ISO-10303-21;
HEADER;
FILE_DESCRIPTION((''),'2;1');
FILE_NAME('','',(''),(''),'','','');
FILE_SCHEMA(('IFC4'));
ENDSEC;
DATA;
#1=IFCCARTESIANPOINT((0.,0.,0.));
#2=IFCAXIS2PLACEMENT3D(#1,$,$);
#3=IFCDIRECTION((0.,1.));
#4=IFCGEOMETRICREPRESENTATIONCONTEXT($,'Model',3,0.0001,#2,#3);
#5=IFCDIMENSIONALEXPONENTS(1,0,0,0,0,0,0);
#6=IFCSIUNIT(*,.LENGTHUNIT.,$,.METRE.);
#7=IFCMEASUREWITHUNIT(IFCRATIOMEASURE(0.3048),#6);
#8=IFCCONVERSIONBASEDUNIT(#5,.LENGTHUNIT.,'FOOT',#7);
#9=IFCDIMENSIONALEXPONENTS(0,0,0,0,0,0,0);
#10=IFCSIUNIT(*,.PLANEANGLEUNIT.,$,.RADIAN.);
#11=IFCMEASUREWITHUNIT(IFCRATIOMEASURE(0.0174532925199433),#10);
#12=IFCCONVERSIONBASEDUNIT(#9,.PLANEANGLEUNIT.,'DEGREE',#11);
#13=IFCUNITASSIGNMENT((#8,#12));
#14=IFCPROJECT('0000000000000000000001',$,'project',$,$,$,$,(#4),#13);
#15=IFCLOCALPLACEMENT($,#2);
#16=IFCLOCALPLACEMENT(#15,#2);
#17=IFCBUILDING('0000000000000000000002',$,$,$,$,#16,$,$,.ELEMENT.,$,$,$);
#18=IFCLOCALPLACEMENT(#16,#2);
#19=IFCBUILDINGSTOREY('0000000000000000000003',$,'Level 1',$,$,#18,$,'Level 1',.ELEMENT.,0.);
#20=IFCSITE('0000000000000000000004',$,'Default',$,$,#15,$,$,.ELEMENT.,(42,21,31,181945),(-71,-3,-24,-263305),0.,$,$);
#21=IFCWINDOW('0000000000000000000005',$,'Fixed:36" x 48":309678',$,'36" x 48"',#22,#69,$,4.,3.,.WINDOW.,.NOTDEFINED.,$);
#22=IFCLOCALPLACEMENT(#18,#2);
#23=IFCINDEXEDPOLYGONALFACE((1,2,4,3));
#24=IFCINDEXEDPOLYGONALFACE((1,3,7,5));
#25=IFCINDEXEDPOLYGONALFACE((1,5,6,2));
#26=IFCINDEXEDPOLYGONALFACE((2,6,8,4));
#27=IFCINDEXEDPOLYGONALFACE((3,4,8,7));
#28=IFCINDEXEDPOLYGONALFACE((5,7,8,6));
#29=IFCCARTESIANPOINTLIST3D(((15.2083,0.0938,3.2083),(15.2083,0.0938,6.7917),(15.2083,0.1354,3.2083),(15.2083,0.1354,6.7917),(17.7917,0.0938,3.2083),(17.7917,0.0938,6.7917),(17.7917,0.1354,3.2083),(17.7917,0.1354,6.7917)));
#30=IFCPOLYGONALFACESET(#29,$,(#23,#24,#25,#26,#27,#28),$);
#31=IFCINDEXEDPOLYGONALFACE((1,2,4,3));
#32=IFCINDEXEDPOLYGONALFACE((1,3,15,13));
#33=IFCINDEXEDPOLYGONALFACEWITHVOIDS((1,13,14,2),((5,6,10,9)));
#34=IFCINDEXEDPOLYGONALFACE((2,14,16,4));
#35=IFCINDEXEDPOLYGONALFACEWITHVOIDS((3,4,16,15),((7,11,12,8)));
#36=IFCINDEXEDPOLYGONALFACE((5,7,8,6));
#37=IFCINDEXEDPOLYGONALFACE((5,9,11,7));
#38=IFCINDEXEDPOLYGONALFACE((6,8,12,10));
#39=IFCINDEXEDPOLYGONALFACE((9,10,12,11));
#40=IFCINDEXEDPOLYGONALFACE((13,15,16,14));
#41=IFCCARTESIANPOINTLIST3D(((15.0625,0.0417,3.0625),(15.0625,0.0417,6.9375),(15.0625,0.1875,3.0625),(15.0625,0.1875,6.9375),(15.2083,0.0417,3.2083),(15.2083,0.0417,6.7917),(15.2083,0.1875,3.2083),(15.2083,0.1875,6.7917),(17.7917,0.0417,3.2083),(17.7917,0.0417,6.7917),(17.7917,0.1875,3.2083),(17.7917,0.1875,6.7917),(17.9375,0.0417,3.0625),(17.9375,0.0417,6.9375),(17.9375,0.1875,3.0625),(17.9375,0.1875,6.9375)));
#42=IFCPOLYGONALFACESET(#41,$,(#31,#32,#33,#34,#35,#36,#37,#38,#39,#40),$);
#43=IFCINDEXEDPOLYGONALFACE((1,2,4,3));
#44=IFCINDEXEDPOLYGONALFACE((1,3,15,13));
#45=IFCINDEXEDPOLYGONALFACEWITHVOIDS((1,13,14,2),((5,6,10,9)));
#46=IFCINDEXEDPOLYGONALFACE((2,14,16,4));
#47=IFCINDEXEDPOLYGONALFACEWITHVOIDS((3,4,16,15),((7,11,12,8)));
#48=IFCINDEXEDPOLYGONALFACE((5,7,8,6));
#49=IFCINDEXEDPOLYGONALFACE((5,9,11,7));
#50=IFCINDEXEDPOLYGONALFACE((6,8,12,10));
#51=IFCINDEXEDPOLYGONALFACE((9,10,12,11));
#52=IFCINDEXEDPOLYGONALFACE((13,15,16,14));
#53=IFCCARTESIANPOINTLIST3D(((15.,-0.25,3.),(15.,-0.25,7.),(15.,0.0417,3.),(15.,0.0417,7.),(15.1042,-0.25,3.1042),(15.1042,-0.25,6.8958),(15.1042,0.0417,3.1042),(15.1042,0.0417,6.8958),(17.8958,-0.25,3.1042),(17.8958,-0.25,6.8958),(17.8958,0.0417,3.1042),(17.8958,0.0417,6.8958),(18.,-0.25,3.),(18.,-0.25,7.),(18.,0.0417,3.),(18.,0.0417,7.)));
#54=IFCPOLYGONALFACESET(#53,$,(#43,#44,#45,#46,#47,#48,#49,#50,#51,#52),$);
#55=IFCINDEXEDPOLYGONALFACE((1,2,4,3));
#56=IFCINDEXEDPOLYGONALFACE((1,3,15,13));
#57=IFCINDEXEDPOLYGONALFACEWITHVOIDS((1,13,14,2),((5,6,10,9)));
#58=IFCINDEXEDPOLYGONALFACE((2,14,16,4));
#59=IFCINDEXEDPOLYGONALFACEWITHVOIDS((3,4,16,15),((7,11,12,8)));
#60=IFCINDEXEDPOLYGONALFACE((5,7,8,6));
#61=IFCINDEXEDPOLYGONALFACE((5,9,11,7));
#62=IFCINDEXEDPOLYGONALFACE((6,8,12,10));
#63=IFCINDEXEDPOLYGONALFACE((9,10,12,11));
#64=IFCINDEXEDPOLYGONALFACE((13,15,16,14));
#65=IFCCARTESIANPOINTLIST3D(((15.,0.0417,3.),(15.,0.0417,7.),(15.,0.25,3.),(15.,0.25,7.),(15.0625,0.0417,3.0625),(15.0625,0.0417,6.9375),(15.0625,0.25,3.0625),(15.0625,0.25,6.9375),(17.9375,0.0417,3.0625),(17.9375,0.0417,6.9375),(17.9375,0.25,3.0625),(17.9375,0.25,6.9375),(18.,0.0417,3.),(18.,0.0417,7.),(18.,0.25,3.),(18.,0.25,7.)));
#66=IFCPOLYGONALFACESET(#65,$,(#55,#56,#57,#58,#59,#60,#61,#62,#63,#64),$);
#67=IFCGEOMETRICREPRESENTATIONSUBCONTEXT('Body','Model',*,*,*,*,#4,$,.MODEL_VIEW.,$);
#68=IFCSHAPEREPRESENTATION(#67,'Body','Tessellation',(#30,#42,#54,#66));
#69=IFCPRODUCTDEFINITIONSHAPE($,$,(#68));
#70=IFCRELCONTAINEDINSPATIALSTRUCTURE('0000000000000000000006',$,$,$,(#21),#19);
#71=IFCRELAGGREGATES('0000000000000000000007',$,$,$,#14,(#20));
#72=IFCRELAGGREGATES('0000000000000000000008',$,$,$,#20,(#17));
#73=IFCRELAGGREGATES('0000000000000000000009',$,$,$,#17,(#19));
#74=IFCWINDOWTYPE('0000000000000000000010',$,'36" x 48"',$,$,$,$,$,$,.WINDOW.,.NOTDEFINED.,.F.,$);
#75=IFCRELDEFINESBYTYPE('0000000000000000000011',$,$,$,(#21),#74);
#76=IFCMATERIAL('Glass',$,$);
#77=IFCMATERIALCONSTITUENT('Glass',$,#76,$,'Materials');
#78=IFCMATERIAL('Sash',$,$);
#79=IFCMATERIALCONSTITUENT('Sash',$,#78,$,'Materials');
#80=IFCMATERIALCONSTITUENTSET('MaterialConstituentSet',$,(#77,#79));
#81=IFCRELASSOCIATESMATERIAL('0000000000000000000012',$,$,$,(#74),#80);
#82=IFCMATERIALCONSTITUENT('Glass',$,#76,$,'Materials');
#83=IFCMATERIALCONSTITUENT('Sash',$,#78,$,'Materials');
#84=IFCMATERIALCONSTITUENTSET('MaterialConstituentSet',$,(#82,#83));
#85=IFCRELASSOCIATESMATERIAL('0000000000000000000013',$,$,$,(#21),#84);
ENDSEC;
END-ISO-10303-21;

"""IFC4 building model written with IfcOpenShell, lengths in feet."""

from ifc_helpers import new_model, entity, si_unit, converted_unit, direction, frame, frame_2d, origin, place, context, subcontext, project, spatial, polyline, rectangle, outline, extrude, source, transform, mapped, material, constituent, constituent_set, type_object, type_shapes, element, save


model = new_model("IFC4")

# Units and contexts
model_context = context("Model", 3, precision=0.0001, world=origin(), true_north=direction((0.0, 1.0)))
body_context = subcontext(model_context, "Body", "Model", "MODEL_VIEW")
ifc_project = project(units=[converted_unit("LENGTHUNIT", "FOOT", entity("IfcRatioMeasure", 0.3048), si_unit("LENGTHUNIT", "METRE"), dimensions=[1, 0, 0, 0, 0, 0, 0]), converted_unit("PLANEANGLEUNIT", "DEGREE", entity("IfcRatioMeasure", 0.0174532925199433), si_unit("PLANEANGLEUNIT", "RADIAN"), dimensions=[0, 0, 0, 0, 0, 0, 0])], contexts=[model_context])

# Site, building, storey
site_placement = place(None, origin())
site = spatial("IfcSite", under=ifc_project, at=site_placement, Name="Default", CompositionType="ELEMENT", RefLatitude=(42, 21, 31, 181945), RefLongitude=(-71, -3, -24, -263305), RefElevation=0.0)
building_placement = place(site_placement, origin())
building = spatial("IfcBuilding", under=site, at=building_placement, CompositionType="ELEMENT")
storey_placement = place(building_placement, origin())
storey = spatial("IfcBuildingStorey", under=building, at=storey_placement, Name="Level 1", LongName="Level 1", CompositionType="ELEMENT", Elevation=0.0)

# Shared definitions
placement_1 = place(storey_placement, frame((46.25, 0.0, 0.0), z_axis=(0.0, 0.0, 1.0), x_axis=(-1.0, 0.0, 0.0)))

# Window
ifc_material_1 = material(Name="Glass")
ifc_constituent_1 = constituent(ifc_material_1, Name="Glass", Category="Materials")
ifc_material_2 = material(Name="Sash")
ifc_constituent_2 = constituent(ifc_material_2, Name="Sash", Category="Materials")
ifc_constituent_set_1 = constituent_set(constituents=[ifc_constituent_1, ifc_constituent_2], Name="MaterialConstituentSet")
ifc_constituent_3 = constituent(ifc_material_1, Name="Glass", Category="Materials")
ifc_constituent_4 = constituent(ifc_material_2, Name="Sash", Category="Materials")
ifc_constituent_set_2 = constituent_set(constituents=[ifc_constituent_3, ifc_constituent_4], Name="MaterialConstituentSet")
window_type = type_object("IfcWindowType", Name="36\" x 48\"", ParameterTakesPrecedence=False, PartitioningType="NOTDEFINED", PredefinedType="WINDOW", material=ifc_constituent_set_2)
shared_shape = source(origin(), body_context, "Body", "SweptSolid", [
    extrude(rectangle(XDim=0.0417, YDim=2.5833, at=frame_2d((0.0, 0.0), x_axis=(1.0, 0.0))), frame((1.5, 0.3646, 0.2083), z_axis=(0.0, 0.0, 1.0), x_axis=(0.0, 1.0, 0.0)), (0.0, 0.0, 1.0), 3.5833),
    extrude(outline(polyline([(-1.4375, -1.9375), (1.4375, -1.9375), (1.4375, 1.9375), (-1.4375, 1.9375), (-1.4375, -1.9375)]), holes=[polyline([(-1.2917, -1.7917), (-1.2917, 1.7917), (1.2917, 1.7917), (1.2917, -1.7917), (-1.2917, -1.7917)])]), frame((1.5, 0.2917, 2.0), z_axis=(0.0, 1.0, 0.0), x_axis=(1.0, 0.0, 0.0)), (0.0, 0.0, 1.0), 0.1458),
    extrude(outline(polyline([(-1.5, -2.0), (1.5, -2.0), (1.5, 2.0), (-1.5, 2.0), (-1.5, -2.0)]), holes=[polyline([(-1.3958, -1.8958), (-1.3958, 1.8958), (1.3958, 1.8958), (1.3958, -1.8958), (-1.3958, -1.8958)])]), frame((1.5, 0.0, 2.0), z_axis=(0.0, 1.0, 0.0), x_axis=(1.0, 0.0, 0.0)), (0.0, 0.0, 1.0), 0.2917),
    extrude(outline(polyline([(-2.0, -1.5), (2.0, -1.5), (2.0, 1.5), (-2.0, 1.5), (-2.0, -1.5)]), holes=[polyline([(-1.9375, -1.4375), (-1.9375, 1.4375), (1.9375, 1.4375), (1.9375, -1.4375), (-1.9375, -1.4375)])]), frame((1.5, 0.2917, 2.0), z_axis=(0.0, 1.0, 0.0), x_axis=(0.0, 0.0, -1.0)), (0.0, 0.0, 1.0), 0.2083),
])
type_shapes(window_type, [shared_shape])
placement_2 = place(placement_1, frame((31.25, 0.25, 3.0)))
window_placement = place(placement_2, frame((0.0, 0.0, 0.0), z_axis=(0.0, 0.0, 1.0), x_axis=(-1.0, 0.0, 0.0)))
element("IfcWindow", 1, at=window_placement, inside=storey, type_object=window_type, material=ifc_constituent_set_1, Name="Fixed:36\" x 48\":309678", ObjectType="36\" x 48\"", OverallHeight=4.0, OverallWidth=3.0, PartitioningType="NOTDEFINED", PredefinedType="WINDOW", context=body_context, shape_type="MappedRepresentation", body=[
    mapped(shared_shape, transform((0.0, 0.0, 0.0), scale=1.0)),
])

save(model, "model.ifc")
